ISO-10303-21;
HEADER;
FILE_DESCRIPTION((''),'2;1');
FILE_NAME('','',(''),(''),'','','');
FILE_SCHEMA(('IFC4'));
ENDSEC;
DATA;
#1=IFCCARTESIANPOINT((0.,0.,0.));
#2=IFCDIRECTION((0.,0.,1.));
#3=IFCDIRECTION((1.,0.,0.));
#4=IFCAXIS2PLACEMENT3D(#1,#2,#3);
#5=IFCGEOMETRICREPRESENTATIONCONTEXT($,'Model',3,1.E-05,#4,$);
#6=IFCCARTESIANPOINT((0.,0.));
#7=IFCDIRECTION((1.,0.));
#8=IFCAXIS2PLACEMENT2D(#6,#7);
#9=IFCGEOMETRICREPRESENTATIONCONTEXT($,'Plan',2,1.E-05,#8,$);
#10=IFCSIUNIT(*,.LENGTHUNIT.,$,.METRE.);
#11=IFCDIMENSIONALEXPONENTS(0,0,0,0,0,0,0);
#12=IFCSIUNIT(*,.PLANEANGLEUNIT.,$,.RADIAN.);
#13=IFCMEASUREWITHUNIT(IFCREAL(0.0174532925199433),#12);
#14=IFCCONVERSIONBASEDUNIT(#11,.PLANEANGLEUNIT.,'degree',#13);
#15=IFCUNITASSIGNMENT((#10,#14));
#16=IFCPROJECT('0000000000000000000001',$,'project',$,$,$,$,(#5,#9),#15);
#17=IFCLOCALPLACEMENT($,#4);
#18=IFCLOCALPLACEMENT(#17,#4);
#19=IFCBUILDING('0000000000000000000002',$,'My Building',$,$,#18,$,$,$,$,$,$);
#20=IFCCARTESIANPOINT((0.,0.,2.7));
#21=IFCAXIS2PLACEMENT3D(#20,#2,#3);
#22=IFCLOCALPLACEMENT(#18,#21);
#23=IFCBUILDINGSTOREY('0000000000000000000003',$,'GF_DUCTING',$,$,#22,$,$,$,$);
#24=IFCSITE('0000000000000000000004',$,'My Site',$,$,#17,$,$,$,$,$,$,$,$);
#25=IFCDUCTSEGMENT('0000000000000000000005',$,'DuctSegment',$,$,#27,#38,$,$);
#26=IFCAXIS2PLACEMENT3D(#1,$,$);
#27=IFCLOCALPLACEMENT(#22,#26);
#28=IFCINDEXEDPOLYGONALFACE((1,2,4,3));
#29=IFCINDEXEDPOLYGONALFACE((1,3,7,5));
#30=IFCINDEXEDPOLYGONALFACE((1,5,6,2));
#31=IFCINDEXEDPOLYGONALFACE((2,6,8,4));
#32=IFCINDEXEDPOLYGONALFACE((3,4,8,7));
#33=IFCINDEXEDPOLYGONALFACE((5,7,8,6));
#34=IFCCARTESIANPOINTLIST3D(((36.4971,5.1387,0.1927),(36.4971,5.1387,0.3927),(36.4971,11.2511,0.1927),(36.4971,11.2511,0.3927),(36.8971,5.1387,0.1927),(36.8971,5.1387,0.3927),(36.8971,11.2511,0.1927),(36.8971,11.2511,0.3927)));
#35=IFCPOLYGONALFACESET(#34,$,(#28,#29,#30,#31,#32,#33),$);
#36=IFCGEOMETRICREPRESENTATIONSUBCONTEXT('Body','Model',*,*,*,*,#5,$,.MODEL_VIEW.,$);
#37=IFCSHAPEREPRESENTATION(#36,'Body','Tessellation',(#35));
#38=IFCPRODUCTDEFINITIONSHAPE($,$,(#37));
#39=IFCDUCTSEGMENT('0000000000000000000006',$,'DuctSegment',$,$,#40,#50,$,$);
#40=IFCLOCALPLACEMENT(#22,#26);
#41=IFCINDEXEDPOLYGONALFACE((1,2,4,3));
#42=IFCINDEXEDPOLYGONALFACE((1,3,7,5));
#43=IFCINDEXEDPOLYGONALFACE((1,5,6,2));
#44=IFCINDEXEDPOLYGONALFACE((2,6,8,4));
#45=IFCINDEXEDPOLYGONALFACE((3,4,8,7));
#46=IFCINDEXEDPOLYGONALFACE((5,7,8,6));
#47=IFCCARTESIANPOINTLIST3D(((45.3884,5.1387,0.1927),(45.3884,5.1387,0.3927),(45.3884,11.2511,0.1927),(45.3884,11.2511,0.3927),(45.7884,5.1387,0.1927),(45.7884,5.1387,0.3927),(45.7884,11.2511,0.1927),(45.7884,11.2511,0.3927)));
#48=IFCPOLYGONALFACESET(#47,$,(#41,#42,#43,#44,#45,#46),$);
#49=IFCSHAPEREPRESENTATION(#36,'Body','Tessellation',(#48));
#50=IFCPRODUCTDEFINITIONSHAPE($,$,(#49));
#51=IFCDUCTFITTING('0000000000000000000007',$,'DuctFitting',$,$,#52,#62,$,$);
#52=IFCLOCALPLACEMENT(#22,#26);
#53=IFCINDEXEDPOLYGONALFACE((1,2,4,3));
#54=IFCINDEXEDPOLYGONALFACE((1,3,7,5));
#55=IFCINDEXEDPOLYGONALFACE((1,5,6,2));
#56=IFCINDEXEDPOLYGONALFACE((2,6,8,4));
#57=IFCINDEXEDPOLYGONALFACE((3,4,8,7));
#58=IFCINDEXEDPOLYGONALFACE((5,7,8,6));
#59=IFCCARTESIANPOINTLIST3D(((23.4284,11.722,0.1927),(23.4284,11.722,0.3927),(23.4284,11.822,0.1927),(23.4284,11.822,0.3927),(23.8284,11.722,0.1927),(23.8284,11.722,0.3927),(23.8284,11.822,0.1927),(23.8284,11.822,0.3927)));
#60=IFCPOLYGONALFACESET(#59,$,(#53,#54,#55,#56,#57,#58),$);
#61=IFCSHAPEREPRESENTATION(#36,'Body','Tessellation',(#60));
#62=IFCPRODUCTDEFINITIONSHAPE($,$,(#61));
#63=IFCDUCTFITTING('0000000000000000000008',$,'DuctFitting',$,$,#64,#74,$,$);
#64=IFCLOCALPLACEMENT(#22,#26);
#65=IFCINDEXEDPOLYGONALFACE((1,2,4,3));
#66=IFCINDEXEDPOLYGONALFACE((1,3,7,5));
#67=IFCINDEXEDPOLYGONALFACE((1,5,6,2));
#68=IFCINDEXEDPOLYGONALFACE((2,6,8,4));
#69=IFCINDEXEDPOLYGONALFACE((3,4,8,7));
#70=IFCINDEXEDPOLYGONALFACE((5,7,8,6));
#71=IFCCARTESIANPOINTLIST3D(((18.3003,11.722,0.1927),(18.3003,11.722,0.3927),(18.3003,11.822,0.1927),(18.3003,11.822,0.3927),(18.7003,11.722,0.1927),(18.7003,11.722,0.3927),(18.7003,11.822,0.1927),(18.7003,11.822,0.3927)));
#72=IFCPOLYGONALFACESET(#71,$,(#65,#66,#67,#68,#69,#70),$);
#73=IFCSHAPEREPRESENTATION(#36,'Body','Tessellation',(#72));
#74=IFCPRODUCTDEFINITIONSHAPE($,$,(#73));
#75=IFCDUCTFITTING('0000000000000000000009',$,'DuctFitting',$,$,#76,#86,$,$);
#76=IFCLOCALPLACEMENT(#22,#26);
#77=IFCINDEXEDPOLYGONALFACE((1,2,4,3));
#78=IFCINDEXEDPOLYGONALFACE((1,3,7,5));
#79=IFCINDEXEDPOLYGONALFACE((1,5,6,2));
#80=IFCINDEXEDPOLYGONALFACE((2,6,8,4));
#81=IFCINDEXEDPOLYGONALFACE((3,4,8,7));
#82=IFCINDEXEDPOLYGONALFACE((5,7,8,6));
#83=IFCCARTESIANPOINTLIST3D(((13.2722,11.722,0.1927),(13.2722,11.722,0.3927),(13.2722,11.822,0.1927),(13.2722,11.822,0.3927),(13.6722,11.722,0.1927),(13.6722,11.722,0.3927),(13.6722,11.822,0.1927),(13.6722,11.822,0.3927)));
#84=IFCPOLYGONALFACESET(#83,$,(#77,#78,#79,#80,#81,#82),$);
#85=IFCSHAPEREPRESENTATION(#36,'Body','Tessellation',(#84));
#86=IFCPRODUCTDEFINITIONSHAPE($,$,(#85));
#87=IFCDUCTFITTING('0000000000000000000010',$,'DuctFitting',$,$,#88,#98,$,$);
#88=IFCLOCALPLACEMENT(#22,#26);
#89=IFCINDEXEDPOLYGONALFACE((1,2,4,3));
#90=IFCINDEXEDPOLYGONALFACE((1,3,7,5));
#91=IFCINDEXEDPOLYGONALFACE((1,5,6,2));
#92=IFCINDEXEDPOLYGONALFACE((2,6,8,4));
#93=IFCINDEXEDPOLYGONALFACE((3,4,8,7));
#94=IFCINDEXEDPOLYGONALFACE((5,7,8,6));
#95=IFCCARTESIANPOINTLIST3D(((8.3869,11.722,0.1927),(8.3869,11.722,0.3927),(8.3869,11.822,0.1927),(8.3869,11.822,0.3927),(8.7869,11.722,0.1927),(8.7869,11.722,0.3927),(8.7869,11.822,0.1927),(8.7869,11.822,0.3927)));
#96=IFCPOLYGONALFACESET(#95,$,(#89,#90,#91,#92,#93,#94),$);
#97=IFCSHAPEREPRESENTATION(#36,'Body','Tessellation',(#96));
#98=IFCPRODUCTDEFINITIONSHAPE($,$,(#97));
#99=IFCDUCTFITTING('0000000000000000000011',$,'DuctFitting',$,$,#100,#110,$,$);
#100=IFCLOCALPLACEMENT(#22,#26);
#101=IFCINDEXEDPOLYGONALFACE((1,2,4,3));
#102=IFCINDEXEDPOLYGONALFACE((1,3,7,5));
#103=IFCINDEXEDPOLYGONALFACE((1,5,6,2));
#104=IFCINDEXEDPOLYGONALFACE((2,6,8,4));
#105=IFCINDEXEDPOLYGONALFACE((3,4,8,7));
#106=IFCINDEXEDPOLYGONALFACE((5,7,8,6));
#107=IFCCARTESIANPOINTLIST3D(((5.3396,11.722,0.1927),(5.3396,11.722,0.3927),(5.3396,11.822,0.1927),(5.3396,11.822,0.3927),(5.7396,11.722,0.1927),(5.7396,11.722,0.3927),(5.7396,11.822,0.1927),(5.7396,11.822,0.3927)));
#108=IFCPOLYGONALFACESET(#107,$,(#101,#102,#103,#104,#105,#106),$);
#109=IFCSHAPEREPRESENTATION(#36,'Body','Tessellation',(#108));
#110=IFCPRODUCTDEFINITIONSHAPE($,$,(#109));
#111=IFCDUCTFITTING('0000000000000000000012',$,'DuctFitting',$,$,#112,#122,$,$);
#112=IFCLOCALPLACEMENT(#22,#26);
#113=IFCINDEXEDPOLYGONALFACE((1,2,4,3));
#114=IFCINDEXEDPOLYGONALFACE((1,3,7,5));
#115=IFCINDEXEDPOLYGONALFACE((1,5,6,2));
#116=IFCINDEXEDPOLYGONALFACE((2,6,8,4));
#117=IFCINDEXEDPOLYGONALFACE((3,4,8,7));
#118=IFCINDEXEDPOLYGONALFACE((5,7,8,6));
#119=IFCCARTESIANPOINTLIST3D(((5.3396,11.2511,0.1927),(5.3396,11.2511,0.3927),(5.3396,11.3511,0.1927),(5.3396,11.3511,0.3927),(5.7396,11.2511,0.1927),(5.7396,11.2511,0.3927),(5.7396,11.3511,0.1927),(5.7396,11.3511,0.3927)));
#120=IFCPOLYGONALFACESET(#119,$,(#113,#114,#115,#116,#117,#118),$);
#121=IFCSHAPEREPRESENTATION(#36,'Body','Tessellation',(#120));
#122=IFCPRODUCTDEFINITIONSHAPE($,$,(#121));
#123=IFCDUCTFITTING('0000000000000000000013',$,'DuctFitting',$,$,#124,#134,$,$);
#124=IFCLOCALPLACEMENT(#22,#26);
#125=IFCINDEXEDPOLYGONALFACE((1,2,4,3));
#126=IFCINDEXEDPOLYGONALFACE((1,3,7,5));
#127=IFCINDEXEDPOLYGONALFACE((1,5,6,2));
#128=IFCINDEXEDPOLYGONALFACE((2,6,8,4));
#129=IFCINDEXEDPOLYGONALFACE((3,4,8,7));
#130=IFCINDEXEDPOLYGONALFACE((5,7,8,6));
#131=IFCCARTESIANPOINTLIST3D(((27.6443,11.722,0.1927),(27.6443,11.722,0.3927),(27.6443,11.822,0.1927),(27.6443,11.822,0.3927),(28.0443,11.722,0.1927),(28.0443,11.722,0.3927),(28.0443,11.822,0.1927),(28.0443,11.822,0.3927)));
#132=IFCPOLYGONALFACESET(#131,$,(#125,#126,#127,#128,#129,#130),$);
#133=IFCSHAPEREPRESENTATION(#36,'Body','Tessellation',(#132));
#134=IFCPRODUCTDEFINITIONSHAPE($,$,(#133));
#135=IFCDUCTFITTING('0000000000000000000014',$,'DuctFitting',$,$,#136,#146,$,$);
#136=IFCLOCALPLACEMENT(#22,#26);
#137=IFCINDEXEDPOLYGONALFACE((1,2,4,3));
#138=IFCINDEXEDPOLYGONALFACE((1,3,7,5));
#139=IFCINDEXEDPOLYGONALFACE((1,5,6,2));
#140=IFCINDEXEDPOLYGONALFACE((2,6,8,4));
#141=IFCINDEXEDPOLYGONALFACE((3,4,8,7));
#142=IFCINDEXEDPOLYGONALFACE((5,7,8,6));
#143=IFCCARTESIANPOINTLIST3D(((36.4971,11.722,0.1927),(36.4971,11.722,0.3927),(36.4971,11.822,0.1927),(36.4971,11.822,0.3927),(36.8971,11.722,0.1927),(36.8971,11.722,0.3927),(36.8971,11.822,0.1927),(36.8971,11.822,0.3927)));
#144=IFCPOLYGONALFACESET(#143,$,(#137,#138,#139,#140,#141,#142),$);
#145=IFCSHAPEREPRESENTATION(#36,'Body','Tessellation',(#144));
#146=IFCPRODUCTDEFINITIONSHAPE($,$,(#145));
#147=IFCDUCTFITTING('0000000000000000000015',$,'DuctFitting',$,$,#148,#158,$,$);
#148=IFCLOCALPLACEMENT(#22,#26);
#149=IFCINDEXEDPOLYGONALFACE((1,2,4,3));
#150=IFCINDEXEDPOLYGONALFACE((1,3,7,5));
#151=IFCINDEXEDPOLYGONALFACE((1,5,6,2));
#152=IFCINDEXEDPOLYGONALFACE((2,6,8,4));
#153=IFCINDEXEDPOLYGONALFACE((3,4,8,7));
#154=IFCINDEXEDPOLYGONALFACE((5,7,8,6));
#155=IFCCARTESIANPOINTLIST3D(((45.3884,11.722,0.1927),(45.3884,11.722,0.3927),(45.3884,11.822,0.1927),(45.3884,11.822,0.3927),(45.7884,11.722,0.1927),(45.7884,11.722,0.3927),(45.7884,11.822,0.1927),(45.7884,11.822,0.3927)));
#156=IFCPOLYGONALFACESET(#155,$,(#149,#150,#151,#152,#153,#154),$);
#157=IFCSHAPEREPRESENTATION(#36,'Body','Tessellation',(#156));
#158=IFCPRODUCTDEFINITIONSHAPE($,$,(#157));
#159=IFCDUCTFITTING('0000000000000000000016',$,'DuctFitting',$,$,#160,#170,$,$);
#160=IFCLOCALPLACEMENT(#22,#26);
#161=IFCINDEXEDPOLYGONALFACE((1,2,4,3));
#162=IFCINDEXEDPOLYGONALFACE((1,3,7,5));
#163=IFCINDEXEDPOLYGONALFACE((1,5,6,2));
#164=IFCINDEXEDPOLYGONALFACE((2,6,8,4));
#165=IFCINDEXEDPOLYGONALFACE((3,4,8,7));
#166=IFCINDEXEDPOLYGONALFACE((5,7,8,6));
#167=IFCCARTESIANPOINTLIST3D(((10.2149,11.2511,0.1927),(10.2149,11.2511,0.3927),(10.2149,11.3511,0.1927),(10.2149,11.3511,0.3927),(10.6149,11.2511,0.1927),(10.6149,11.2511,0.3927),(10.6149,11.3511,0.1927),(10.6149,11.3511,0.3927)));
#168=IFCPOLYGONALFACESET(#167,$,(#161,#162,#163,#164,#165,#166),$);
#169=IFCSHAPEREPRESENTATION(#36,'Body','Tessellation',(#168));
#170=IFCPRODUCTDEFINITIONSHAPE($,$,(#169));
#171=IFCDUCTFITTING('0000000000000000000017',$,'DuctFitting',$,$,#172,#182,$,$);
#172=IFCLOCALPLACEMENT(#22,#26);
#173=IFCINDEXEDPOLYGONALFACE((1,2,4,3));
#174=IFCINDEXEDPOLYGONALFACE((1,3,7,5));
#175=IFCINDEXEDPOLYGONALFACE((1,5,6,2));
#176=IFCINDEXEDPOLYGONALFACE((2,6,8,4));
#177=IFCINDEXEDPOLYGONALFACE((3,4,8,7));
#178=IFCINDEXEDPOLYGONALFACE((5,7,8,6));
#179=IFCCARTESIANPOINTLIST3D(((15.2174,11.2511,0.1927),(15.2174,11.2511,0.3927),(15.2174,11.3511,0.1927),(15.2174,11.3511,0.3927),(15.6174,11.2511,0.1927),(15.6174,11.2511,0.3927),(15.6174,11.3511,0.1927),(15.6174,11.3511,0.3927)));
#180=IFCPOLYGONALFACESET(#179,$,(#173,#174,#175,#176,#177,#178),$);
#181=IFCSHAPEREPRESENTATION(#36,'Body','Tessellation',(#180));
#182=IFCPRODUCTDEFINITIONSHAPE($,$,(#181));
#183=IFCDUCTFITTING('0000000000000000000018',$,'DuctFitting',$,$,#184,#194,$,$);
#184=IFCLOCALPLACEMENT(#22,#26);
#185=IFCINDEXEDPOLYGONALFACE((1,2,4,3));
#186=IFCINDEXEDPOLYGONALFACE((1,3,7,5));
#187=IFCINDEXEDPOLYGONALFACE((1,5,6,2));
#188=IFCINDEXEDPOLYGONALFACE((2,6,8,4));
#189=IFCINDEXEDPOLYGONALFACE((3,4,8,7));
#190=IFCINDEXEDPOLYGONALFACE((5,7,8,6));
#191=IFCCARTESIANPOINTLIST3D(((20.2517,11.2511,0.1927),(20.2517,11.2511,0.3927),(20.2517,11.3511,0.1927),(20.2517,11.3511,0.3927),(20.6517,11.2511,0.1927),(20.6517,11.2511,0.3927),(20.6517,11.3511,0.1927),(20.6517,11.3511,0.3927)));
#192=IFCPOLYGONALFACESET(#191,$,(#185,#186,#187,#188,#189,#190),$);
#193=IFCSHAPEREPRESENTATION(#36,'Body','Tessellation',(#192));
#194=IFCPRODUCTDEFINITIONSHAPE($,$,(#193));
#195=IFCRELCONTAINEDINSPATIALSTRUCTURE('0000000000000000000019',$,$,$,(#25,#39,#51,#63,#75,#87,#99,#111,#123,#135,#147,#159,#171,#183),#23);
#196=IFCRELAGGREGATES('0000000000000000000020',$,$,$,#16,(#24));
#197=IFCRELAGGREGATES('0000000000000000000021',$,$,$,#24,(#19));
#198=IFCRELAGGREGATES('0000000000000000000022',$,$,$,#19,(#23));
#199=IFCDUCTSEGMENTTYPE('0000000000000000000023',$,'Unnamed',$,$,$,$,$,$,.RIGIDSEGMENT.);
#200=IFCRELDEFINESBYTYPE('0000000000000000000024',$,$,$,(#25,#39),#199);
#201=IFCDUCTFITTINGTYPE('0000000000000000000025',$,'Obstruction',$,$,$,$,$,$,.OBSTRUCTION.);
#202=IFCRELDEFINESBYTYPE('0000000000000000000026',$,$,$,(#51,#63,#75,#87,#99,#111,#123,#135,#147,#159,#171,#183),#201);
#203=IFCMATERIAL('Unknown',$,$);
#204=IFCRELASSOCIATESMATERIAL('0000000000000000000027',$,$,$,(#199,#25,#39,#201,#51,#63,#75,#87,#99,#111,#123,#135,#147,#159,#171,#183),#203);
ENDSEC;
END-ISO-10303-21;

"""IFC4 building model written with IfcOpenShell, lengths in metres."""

from ifc_helpers import new_model, entity, si_unit, converted_unit, frame, origin_with_axes, origin_2d_with_axis, place, context, subcontext, project, spatial, rectangle, extrude, material, material_profile, profile_set, profile_usage, type_object, element, save


model = new_model("IFC4")

# Units and contexts
model_context = context("Model", 3, precision=1e-05, world=origin_with_axes())
plan_context = context("Plan", 2, precision=1e-05, world=origin_2d_with_axis())
body_context = subcontext(model_context, "Body", "Model", "MODEL_VIEW")
ifc_project = project(units=[si_unit("LENGTHUNIT", "METRE"), converted_unit("PLANEANGLEUNIT", "degree", entity("IfcReal", 0.0174532925199433), si_unit("PLANEANGLEUNIT", "RADIAN"), dimensions=[0, 0, 0, 0, 0, 0, 0])], contexts=[model_context, plan_context])

# Site, building, storey
site_placement = place(None, origin_with_axes())
site = spatial("IfcSite", under=ifc_project, at=site_placement, Name="My Site")
building_placement = place(site_placement, origin_with_axes())
building = spatial("IfcBuilding", under=site, at=building_placement, Name="My Building")
storey_placement = place(building_placement, frame((0.0, 0.0, 2.7), z_axis=(0.0, 0.0, 1.0), x_axis=(1.0, 0.0, 0.0)))
storey = spatial("IfcBuildingStorey", under=building, at=storey_placement, Name="GF_DUCTING")

# Duct segments
ifc_material = material(Name="Unknown")
ifc_material_profile_1 = material_profile(ifc_material, rectangle(XDim=0.4, YDim=0.2))
ifc_profile_set_1 = profile_set([ifc_material_profile_1])
duct_segment_type = type_object("IfcDuctSegmentType", Name="Unnamed", PredefinedType="RIGIDSEGMENT", material=ifc_profile_set_1)
ifc_profile_usage_1 = profile_usage(ifc_profile_set_1, cardinal=5)
duct_segment_1_placement = place(storey_placement, frame((36.6971, 5.1387, 0.2927), z_axis=(0.0, 1.0, 0.0), x_axis=(-1.0, 0.0, 0.0)))
element("IfcDuctSegment", 1, at=duct_segment_1_placement, inside=storey, type_object=duct_segment_type, material=ifc_profile_usage_1, Name="DuctSegment", context=body_context, shape_type="SweptSolid", body=[
    extrude(rectangle(XDim=0.4, YDim=0.2), origin_with_axes(), (0.0, 0.0, 1.0), 6.1124),
])
ifc_profile_usage_2 = profile_usage(ifc_profile_set_1, cardinal=5)
duct_segment_2_placement = place(storey_placement, frame((45.5884, 5.1387, 0.2927), z_axis=(0.0, 1.0, 0.0), x_axis=(-1.0, 0.0, 0.0)))
element("IfcDuctSegment", 2, at=duct_segment_2_placement, inside=storey, type_object=duct_segment_type, material=ifc_profile_usage_2, Name="DuctSegment", context=body_context, shape_type="SweptSolid", body=[
    extrude(rectangle(XDim=0.4, YDim=0.2), origin_with_axes(), (0.0, 0.0, 1.0), 6.1124),
])

# Duct fittings
ifc_material_profile_2 = material_profile(ifc_material, rectangle(XDim=0.4, YDim=0.2))
ifc_profile_set_2 = profile_set([ifc_material_profile_2])
ifc_profile_usage_3 = profile_usage(ifc_profile_set_2, cardinal=5)
duct_fitting_type = type_object("IfcDuctFittingType", Name="Obstruction", PredefinedType="OBSTRUCTION", material=ifc_profile_set_2)
duct_fitting_1_placement = place(storey_placement, frame((23.6284, 11.822, 0.2927), z_axis=(0.0, -1.0, 0.0), x_axis=(1.0, 0.0, 0.0)))
element("IfcDuctFitting", 3, at=duct_fitting_1_placement, inside=storey, type_object=duct_fitting_type, material=ifc_profile_usage_3, Name="DuctFitting", context=body_context, shape_type="SweptSolid", body=[
    extrude(rectangle(XDim=0.4, YDim=0.2), origin_with_axes(), (0.0, 0.0, 1.0), 0.1),
])
ifc_profile_usage_4 = profile_usage(ifc_profile_set_2, cardinal=5)
duct_fitting_2_placement = place(storey_placement, frame((18.5003, 11.822, 0.2927), z_axis=(0.0, -1.0, 0.0), x_axis=(1.0, 0.0, 0.0)))
element("IfcDuctFitting", 4, at=duct_fitting_2_placement, inside=storey, type_object=duct_fitting_type, material=ifc_profile_usage_4, Name="DuctFitting", context=body_context, shape_type="SweptSolid", body=[
    extrude(rectangle(XDim=0.4, YDim=0.2), origin_with_axes(), (0.0, 0.0, 1.0), 0.1),
])
ifc_profile_usage_5 = profile_usage(ifc_profile_set_2, cardinal=5)
duct_fitting_3_placement = place(storey_placement, frame((13.4722, 11.822, 0.2927), z_axis=(0.0, -1.0, 0.0), x_axis=(1.0, 0.0, 0.0)))
element("IfcDuctFitting", 5, at=duct_fitting_3_placement, inside=storey, type_object=duct_fitting_type, material=ifc_profile_usage_5, Name="DuctFitting", context=body_context, shape_type="SweptSolid", body=[
    extrude(rectangle(XDim=0.4, YDim=0.2), origin_with_axes(), (0.0, 0.0, 1.0), 0.1),
])
ifc_profile_usage_6 = profile_usage(ifc_profile_set_2, cardinal=5)
duct_fitting_4_placement = place(storey_placement, frame((8.5869, 11.822, 0.2927), z_axis=(0.0, -1.0, 0.0), x_axis=(1.0, 0.0, 0.0)))
element("IfcDuctFitting", 6, at=duct_fitting_4_placement, inside=storey, type_object=duct_fitting_type, material=ifc_profile_usage_6, Name="DuctFitting", context=body_context, shape_type="SweptSolid", body=[
    extrude(rectangle(XDim=0.4, YDim=0.2), origin_with_axes(), (0.0, 0.0, 1.0), 0.1),
])
ifc_profile_usage_7 = profile_usage(ifc_profile_set_2, cardinal=5)
duct_fitting_5_placement = place(storey_placement, frame((5.5396, 11.822, 0.2927), z_axis=(0.0, -1.0, 0.0), x_axis=(1.0, 0.0, 0.0)))
element("IfcDuctFitting", 7, at=duct_fitting_5_placement, inside=storey, type_object=duct_fitting_type, material=ifc_profile_usage_7, Name="DuctFitting", context=body_context, shape_type="SweptSolid", body=[
    extrude(rectangle(XDim=0.4, YDim=0.2), origin_with_axes(), (0.0, 0.0, 1.0), 0.1),
])
ifc_profile_usage_8 = profile_usage(ifc_profile_set_2, cardinal=5)
duct_fitting_6_placement = place(storey_placement, frame((5.5396, 11.2511, 0.2927), z_axis=(0.0, 1.0, 0.0), x_axis=(-1.0, 0.0, 0.0)))
element("IfcDuctFitting", 8, at=duct_fitting_6_placement, inside=storey, type_object=duct_fitting_type, material=ifc_profile_usage_8, Name="DuctFitting", context=body_context, shape_type="SweptSolid", body=[
    extrude(rectangle(XDim=0.4, YDim=0.2), origin_with_axes(), (0.0, 0.0, 1.0), 0.1),
])
ifc_profile_usage_9 = profile_usage(ifc_profile_set_2, cardinal=5)
duct_fitting_7_placement = place(storey_placement, frame((27.8443, 11.822, 0.2927), z_axis=(0.0, -1.0, 0.0), x_axis=(1.0, 0.0, 0.0)))
element("IfcDuctFitting", 9, at=duct_fitting_7_placement, inside=storey, type_object=duct_fitting_type, material=ifc_profile_usage_9, Name="DuctFitting", context=body_context, shape_type="SweptSolid", body=[
    extrude(rectangle(XDim=0.4, YDim=0.2), origin_with_axes(), (0.0, 0.0, 1.0), 0.1),
])
ifc_profile_usage_10 = profile_usage(ifc_profile_set_2, cardinal=5)
duct_fitting_8_placement = place(storey_placement, frame((36.6971, 11.822, 0.2927), z_axis=(0.0, -1.0, 0.0), x_axis=(1.0, 0.0, 0.0)))
element("IfcDuctFitting", 10, at=duct_fitting_8_placement, inside=storey, type_object=duct_fitting_type, material=ifc_profile_usage_10, Name="DuctFitting", context=body_context, shape_type="SweptSolid", body=[
    extrude(rectangle(XDim=0.4, YDim=0.2), origin_with_axes(), (0.0, 0.0, 1.0), 0.1),
])
ifc_profile_usage_11 = profile_usage(ifc_profile_set_2, cardinal=5)
duct_fitting_9_placement = place(storey_placement, frame((45.5884, 11.822, 0.2927), z_axis=(0.0, -1.0, 0.0), x_axis=(1.0, 0.0, 0.0)))
element("IfcDuctFitting", 11, at=duct_fitting_9_placement, inside=storey, type_object=duct_fitting_type, material=ifc_profile_usage_11, Name="DuctFitting", context=body_context, shape_type="SweptSolid", body=[
    extrude(rectangle(XDim=0.4, YDim=0.2), origin_with_axes(), (0.0, 0.0, 1.0), 0.1),
])
ifc_profile_usage_12 = profile_usage(ifc_profile_set_2, cardinal=5)
duct_fitting_10_placement = place(storey_placement, frame((10.4149, 11.2511, 0.2927), z_axis=(0.0, 1.0, 0.0), x_axis=(-1.0, 0.0, 0.0)))
element("IfcDuctFitting", 12, at=duct_fitting_10_placement, inside=storey, type_object=duct_fitting_type, material=ifc_profile_usage_12, Name="DuctFitting", context=body_context, shape_type="SweptSolid", body=[
    extrude(rectangle(XDim=0.4, YDim=0.2), origin_with_axes(), (0.0, 0.0, 1.0), 0.1),
])
ifc_profile_usage_13 = profile_usage(ifc_profile_set_2, cardinal=5)
duct_fitting_11_placement = place(storey_placement, frame((15.4174, 11.2511, 0.2927), z_axis=(0.0, 1.0, 0.0), x_axis=(-1.0, 0.0, 0.0)))
element("IfcDuctFitting", 13, at=duct_fitting_11_placement, inside=storey, type_object=duct_fitting_type, material=ifc_profile_usage_13, Name="DuctFitting", context=body_context, shape_type="SweptSolid", body=[
    extrude(rectangle(XDim=0.4, YDim=0.2), origin_with_axes(), (0.0, 0.0, 1.0), 0.1),
])
ifc_profile_usage_14 = profile_usage(ifc_profile_set_2, cardinal=5)
duct_fitting_12_placement = place(storey_placement, frame((20.4517, 11.2511, 0.2927), z_axis=(0.0, 1.0, 0.0), x_axis=(-1.0, 0.0, 0.0)))
element("IfcDuctFitting", 14, at=duct_fitting_12_placement, inside=storey, type_object=duct_fitting_type, material=ifc_profile_usage_14, Name="DuctFitting", context=body_context, shape_type="SweptSolid", body=[
    extrude(rectangle(XDim=0.4, YDim=0.2), origin_with_axes(), (0.0, 0.0, 1.0), 0.1),
])

save(model, "model.ifc")
